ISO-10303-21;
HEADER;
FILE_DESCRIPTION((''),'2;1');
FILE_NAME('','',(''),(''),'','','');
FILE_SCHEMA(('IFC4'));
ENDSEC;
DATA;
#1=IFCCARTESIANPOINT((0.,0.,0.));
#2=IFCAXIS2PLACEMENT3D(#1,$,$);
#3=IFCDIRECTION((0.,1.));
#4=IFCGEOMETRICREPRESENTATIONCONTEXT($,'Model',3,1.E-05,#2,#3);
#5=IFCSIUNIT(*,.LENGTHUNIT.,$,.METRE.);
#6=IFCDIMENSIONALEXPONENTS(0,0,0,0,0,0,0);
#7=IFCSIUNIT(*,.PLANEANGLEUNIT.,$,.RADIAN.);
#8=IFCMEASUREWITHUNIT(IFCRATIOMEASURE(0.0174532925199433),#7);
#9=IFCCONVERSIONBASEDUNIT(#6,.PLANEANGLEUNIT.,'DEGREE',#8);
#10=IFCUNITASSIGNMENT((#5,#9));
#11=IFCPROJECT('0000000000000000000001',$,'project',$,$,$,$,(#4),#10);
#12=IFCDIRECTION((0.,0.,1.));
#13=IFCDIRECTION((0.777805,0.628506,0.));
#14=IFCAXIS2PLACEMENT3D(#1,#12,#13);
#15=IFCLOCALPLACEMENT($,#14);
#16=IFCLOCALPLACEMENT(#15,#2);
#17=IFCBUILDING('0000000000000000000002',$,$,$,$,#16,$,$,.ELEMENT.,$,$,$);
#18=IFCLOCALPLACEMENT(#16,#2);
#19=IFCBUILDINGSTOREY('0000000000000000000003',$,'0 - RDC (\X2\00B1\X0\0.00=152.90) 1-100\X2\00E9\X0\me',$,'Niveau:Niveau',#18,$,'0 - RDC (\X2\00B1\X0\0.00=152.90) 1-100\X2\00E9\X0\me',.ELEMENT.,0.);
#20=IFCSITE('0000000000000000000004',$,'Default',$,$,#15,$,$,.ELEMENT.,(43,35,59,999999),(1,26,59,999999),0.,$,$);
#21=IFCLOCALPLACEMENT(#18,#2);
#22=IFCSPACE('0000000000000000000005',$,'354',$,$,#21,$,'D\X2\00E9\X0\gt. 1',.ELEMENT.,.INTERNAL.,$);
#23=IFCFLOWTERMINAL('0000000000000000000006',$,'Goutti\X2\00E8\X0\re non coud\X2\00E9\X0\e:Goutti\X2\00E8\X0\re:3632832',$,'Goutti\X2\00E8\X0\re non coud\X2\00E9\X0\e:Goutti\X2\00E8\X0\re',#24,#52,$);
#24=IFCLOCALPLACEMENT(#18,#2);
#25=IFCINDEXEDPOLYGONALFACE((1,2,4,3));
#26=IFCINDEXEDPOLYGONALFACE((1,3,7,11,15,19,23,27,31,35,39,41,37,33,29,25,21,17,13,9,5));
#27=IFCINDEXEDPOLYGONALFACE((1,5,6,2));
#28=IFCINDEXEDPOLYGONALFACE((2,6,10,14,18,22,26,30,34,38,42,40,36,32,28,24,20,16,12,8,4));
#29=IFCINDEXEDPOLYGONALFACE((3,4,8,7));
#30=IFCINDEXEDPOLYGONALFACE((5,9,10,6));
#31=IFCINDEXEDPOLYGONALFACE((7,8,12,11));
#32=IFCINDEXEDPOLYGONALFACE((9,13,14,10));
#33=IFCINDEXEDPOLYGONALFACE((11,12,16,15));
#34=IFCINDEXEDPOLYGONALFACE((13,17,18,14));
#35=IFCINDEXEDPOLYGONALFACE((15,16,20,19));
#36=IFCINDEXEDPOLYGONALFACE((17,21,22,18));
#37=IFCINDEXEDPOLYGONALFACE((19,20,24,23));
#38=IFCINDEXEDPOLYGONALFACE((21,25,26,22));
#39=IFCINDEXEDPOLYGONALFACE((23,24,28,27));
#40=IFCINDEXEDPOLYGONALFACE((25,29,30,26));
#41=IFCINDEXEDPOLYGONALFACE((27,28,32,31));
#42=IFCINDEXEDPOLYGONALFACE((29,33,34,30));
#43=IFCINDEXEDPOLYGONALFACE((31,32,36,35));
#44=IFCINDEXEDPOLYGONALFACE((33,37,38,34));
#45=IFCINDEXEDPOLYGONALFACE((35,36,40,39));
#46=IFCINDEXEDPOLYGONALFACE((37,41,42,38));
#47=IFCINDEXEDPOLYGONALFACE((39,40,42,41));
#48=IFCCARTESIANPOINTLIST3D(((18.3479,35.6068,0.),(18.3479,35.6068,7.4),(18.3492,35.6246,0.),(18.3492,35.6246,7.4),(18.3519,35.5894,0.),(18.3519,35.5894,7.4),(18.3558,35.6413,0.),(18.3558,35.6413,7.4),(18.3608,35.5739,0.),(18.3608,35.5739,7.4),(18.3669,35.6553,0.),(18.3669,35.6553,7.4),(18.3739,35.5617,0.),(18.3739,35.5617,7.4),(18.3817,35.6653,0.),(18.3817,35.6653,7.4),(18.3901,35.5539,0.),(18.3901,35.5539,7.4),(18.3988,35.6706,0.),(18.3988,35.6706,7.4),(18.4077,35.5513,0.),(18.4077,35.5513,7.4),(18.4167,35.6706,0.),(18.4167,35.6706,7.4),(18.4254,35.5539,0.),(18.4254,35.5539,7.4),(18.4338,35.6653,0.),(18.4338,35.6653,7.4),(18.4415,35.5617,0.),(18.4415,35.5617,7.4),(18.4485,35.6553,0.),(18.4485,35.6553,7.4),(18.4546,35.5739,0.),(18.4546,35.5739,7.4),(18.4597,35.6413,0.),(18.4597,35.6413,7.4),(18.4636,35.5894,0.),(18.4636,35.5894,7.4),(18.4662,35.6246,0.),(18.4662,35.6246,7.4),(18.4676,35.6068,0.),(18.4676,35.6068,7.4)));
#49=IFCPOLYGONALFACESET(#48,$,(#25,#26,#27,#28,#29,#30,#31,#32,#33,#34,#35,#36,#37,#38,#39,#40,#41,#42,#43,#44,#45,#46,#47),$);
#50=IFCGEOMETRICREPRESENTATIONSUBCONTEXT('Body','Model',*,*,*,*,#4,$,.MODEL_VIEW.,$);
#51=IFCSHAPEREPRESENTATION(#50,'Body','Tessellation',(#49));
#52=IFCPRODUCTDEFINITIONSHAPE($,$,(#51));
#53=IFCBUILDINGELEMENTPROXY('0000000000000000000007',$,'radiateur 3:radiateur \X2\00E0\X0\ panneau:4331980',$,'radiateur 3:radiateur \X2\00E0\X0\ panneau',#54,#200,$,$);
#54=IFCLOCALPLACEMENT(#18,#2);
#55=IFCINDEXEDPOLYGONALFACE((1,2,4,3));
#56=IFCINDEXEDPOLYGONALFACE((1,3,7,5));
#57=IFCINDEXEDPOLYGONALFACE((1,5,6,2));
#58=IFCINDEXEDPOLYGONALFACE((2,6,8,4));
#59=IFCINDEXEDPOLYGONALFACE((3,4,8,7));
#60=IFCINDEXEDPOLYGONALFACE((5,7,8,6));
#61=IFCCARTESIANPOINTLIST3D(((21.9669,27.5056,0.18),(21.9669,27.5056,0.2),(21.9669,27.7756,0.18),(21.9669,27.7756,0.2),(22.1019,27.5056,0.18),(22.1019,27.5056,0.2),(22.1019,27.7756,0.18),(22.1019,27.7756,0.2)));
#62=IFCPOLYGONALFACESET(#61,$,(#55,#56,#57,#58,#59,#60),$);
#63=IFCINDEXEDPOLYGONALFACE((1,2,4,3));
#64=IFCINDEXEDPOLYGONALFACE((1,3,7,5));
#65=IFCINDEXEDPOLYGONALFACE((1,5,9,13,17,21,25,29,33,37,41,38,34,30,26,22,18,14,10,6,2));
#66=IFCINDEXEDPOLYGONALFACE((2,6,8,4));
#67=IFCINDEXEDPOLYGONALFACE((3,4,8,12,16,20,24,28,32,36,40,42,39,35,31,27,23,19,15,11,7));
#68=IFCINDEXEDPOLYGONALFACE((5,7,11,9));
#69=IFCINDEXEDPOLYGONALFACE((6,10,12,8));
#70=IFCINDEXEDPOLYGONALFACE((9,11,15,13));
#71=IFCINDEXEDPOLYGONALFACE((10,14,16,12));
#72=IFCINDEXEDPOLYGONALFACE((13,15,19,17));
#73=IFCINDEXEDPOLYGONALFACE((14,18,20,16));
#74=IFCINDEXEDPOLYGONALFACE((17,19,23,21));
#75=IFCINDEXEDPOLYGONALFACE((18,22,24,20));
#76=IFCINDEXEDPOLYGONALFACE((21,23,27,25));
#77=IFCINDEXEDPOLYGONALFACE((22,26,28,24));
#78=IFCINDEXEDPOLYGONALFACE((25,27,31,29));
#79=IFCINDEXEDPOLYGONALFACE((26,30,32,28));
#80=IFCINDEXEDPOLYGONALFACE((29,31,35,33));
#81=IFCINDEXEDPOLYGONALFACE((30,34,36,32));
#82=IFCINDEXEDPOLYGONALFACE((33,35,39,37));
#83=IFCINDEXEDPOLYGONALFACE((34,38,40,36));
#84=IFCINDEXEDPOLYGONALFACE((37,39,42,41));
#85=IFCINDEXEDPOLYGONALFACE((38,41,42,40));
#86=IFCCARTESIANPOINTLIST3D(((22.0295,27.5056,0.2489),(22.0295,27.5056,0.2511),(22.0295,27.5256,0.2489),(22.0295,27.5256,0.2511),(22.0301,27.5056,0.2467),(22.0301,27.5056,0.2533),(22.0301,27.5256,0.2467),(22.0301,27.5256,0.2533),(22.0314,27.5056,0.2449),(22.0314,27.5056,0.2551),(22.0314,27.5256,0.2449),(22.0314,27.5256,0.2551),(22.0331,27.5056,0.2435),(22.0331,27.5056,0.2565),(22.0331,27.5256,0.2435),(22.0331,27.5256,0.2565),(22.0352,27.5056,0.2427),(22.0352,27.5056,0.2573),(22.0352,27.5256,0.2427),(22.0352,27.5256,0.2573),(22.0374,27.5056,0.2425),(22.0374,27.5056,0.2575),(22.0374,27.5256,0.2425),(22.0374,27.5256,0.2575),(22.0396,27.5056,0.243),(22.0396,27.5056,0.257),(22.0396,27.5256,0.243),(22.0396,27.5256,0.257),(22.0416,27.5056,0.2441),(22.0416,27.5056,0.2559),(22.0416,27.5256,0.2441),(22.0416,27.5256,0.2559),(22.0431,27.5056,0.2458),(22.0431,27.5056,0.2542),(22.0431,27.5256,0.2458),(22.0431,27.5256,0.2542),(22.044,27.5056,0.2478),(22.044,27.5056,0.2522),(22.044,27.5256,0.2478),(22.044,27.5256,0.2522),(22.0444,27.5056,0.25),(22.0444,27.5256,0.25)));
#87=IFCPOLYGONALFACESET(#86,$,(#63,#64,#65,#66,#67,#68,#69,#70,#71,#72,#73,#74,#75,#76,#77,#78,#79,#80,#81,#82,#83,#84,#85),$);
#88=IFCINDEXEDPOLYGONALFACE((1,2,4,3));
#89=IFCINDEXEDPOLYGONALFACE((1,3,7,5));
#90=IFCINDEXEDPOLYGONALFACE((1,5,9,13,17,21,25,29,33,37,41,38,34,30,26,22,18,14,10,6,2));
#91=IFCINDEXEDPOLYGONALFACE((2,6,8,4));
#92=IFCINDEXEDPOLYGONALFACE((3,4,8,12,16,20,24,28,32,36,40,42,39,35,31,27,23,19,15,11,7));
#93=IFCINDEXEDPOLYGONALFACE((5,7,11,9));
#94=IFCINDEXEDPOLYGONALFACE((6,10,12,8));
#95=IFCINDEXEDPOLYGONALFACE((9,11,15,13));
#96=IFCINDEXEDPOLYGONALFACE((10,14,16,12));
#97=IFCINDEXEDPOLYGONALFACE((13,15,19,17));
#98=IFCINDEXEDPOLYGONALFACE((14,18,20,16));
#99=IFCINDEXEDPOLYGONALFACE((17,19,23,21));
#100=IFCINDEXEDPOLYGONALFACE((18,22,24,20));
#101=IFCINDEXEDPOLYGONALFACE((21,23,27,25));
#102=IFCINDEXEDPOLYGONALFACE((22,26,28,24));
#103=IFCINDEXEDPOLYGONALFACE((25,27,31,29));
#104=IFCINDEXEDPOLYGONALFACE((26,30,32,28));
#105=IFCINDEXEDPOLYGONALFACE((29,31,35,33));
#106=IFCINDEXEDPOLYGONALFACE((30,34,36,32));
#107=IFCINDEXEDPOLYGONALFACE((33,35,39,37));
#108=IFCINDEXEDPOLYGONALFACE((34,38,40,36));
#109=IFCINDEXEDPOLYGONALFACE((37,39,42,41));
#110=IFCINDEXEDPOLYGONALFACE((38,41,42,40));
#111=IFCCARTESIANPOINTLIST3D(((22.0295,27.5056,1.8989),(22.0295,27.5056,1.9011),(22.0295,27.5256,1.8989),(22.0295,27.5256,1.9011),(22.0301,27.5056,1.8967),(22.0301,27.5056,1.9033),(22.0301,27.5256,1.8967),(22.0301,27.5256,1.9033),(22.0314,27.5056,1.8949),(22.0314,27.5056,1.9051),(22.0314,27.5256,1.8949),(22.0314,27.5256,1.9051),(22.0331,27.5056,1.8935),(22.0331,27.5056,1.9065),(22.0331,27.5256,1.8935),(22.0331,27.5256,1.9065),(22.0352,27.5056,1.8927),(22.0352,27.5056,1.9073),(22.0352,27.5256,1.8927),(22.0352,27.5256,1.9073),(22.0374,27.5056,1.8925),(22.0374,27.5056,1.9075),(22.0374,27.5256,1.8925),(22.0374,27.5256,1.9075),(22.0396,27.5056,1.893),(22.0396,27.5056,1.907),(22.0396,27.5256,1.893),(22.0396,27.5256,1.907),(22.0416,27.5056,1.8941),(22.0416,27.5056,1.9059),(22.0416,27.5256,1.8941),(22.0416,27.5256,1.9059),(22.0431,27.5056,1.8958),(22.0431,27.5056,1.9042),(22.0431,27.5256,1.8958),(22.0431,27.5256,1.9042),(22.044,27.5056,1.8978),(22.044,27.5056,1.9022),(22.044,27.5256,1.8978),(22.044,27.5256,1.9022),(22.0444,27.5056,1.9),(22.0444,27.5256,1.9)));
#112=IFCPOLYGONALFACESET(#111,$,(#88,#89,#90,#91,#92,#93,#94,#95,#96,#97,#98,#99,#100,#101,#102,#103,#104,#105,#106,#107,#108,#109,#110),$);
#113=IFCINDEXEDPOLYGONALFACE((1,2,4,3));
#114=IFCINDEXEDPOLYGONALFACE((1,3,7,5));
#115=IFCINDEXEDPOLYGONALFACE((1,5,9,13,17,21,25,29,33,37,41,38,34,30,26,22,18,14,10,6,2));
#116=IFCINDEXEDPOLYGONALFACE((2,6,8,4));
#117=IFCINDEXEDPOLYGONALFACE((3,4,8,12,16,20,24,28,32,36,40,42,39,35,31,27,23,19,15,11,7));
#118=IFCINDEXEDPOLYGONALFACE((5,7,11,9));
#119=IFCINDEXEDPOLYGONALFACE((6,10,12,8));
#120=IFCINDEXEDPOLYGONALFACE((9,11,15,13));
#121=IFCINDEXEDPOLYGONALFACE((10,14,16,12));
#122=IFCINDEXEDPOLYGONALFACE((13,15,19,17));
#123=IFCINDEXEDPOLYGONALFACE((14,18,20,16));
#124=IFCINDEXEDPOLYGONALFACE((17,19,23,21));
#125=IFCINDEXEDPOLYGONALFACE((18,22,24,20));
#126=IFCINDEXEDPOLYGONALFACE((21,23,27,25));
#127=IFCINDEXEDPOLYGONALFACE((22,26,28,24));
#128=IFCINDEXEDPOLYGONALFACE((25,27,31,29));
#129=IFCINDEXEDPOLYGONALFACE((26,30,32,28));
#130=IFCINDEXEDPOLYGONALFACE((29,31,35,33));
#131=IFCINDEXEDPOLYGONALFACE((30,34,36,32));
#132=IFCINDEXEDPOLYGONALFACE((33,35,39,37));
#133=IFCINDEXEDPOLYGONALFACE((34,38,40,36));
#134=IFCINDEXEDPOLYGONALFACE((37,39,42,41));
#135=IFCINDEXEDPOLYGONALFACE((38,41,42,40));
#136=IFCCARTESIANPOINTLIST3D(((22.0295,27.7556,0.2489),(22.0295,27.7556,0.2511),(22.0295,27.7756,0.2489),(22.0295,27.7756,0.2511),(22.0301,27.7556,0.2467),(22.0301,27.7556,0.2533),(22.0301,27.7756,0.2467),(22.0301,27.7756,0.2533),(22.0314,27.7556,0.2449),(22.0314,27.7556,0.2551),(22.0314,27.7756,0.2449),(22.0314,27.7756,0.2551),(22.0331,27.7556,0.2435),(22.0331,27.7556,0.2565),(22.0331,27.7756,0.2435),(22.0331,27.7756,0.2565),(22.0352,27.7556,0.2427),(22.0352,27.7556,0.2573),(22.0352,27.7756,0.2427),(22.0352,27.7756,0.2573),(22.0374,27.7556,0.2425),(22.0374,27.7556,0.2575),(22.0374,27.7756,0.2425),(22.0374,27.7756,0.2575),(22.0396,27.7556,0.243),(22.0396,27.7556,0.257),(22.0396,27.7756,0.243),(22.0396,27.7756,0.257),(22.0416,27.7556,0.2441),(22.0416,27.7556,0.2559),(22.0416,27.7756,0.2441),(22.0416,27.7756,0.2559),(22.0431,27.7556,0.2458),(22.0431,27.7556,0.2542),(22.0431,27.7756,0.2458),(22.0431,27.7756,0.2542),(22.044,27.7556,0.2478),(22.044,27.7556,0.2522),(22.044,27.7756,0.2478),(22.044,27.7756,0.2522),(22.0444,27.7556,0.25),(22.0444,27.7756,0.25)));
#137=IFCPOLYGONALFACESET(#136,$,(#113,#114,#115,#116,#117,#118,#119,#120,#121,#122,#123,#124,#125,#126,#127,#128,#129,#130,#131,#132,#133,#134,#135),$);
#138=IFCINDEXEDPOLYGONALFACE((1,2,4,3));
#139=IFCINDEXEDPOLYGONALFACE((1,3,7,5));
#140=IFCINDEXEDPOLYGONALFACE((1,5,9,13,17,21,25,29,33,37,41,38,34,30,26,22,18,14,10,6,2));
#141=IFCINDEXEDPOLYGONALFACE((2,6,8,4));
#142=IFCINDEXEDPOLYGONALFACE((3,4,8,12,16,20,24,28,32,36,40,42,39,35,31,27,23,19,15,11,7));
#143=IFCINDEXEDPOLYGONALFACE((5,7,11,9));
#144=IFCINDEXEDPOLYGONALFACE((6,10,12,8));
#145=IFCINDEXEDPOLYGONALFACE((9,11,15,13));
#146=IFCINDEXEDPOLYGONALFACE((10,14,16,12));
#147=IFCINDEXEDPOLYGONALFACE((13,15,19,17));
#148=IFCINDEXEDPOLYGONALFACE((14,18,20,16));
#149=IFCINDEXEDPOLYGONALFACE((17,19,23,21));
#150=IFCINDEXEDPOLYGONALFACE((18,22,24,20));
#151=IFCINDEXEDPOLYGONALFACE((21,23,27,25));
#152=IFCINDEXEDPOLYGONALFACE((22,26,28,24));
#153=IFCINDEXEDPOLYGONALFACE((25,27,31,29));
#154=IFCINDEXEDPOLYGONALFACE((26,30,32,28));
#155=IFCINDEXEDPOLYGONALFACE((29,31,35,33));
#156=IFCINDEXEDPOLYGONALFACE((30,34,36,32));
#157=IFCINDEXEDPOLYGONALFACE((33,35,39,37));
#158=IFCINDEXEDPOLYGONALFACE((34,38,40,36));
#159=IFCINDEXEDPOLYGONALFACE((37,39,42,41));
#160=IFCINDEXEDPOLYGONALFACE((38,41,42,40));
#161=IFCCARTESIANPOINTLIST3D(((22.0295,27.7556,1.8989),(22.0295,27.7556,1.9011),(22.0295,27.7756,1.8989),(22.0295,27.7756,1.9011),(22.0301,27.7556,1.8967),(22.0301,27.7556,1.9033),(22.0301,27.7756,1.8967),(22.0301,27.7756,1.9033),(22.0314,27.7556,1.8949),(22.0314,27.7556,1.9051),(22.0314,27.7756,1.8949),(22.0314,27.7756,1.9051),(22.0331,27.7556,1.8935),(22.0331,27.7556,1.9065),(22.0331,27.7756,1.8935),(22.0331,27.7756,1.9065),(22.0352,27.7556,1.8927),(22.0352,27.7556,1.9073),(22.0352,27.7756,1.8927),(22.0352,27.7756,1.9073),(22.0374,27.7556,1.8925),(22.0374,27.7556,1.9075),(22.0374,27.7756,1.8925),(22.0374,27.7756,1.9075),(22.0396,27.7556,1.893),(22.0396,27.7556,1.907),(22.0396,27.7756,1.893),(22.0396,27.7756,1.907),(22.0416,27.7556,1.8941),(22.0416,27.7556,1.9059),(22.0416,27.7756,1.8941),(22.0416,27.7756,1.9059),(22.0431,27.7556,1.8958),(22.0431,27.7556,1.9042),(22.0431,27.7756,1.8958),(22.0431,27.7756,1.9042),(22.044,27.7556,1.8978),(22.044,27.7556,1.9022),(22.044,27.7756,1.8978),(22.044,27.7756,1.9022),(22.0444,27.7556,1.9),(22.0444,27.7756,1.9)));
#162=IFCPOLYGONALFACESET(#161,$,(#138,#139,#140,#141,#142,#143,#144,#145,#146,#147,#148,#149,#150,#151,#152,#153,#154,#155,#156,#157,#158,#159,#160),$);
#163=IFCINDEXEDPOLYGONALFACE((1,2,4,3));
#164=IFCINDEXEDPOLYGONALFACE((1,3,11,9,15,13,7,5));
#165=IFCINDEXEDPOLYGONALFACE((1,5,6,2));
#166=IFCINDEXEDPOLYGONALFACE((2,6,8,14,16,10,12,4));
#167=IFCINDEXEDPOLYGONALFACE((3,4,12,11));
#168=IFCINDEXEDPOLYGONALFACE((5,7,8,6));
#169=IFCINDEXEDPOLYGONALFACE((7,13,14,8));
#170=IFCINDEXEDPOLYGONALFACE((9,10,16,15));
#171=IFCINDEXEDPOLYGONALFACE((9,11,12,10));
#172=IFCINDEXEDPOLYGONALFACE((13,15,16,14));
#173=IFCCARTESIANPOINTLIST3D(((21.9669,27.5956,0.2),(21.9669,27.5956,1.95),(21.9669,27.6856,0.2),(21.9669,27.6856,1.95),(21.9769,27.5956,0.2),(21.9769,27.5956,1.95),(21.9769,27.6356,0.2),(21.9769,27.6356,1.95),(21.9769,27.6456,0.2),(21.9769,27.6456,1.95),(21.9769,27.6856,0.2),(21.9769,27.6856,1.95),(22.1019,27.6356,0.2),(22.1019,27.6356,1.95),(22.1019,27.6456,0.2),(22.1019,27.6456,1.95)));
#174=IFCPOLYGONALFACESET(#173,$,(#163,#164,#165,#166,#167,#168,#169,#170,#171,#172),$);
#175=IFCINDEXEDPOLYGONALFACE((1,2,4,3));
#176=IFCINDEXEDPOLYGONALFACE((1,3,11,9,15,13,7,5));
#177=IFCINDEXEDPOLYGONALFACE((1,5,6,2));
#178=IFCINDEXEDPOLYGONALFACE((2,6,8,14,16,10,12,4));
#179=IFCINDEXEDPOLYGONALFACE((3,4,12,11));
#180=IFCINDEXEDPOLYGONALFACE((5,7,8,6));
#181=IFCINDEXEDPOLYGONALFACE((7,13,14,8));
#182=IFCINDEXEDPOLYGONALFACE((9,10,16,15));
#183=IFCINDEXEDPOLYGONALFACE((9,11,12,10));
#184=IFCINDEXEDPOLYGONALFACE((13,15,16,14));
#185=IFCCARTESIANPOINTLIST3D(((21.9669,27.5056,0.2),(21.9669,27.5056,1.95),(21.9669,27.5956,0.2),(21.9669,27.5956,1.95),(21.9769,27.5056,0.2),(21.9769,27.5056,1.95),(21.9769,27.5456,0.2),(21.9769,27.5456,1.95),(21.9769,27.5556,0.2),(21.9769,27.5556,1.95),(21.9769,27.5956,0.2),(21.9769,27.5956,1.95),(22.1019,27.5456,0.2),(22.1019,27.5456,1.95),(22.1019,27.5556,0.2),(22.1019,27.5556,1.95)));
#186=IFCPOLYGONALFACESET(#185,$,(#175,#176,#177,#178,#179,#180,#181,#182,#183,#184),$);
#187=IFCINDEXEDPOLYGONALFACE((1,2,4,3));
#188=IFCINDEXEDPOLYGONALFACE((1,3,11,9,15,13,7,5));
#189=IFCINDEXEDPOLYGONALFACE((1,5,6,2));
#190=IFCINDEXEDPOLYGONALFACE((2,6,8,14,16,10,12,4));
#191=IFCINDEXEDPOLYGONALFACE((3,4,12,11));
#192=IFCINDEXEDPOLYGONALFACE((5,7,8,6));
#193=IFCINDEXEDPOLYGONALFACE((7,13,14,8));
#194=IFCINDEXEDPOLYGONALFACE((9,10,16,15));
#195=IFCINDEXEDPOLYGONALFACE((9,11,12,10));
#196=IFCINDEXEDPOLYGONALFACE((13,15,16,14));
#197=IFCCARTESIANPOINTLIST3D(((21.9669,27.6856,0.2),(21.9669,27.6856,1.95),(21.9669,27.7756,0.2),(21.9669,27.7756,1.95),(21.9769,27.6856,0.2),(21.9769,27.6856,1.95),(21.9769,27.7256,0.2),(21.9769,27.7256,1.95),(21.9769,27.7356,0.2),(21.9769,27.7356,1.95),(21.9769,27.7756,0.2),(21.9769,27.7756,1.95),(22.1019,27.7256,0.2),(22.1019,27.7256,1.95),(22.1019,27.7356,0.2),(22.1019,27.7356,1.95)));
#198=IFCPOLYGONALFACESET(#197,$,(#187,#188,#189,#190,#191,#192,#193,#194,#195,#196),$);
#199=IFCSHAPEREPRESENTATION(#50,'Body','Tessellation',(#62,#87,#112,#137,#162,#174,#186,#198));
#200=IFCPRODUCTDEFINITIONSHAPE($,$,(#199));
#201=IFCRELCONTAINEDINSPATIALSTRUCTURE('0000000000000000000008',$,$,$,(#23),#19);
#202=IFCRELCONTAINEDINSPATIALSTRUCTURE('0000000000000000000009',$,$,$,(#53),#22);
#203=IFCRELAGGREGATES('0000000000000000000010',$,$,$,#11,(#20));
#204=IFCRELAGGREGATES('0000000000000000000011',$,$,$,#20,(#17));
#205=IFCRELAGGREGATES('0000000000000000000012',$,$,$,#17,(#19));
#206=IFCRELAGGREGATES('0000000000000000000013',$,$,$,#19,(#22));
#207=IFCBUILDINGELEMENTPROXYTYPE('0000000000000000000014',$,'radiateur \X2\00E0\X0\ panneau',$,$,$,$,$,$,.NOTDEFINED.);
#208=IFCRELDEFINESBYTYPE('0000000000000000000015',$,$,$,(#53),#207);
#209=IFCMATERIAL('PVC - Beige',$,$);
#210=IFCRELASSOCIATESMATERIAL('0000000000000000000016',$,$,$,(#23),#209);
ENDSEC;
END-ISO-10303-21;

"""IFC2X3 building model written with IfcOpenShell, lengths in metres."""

from ifc_helpers import new_model, entity, si_unit, converted_unit, direction, frame, frame_2d, origin, origin_2d_with_axis, place, context, subcontext, project, spatial, polyline, rectangle, circle, outline, extrude, source, transform, mapped, material, type_object, type_shapes, element, save


model = new_model("IFC2X3")

# Units and contexts
model_context = context("Model", 3, precision=1e-05, world=origin(), true_north=direction((0.0, 1.0)))
body_context = subcontext(model_context, "Body", "Model", "MODEL_VIEW")
ifc_project = project(units=[si_unit("LENGTHUNIT", "METRE"), converted_unit("PLANEANGLEUNIT", "DEGREE", entity("IfcRatioMeasure", 0.0174532925199433), si_unit("PLANEANGLEUNIT", "RADIAN"), dimensions=[0, 0, 0, 0, 0, 0, 0])], contexts=[model_context])

# Site, building, storey
site_placement = place(None, frame((0.0, 0.0, 0.0), z_axis=(0.0, 0.0, 1.0), x_axis=(0.777805, 0.628506, 0.0)))
site = spatial("IfcSite", under=ifc_project, at=site_placement, Name="Default", CompositionType="ELEMENT", RefLatitude=(43, 35, 59, 999999), RefLongitude=(1, 26, 59, 999999), RefElevation=0.0)
building_placement = place(site_placement, origin())
building = spatial("IfcBuilding", under=site, at=building_placement, CompositionType="ELEMENT")
storey_placement = place(building_placement, origin())
storey = spatial("IfcBuildingStorey", under=building, at=storey_placement, Name="0 - RDC (±0.00=152.90) 1-100éme", ObjectType="Niveau:Niveau", LongName="0 - RDC (±0.00=152.90) 1-100éme", CompositionType="ELEMENT", Elevation=0.0)

# Flow terminal
ifc_material_1 = material(Name="PVC - Beige")
shared_shape_1 = source(origin(), body_context, "Body", "SweptSolid", [
    extrude(circle(Radius=0.06, at=frame_2d((0.0, 0.0), x_axis=(1.0, 0.0))), frame((0.0, 0.0, 0.0), z_axis=(0.0, 0.0, 1.0), x_axis=(0.0, -1.0, 0.0)), (0.0, 0.0, 1.0), 7.4),
])
flow_terminal_1_placement = place(storey_placement, frame((18.4077, 35.6113, 0.0)))
element("IfcFlowTerminal", 1, at=flow_terminal_1_placement, inside=storey, material=ifc_material_1, Name="Gouttière non coudée:Gouttière:3632832", ObjectType="Gouttière non coudée:Gouttière", context=body_context, shape_type="MappedRepresentation", body=[
    mapped(shared_shape_1, transform((0.0, 0.0, 0.0), scale=1.0)),
])

# Shared definitions
space_1_placement = place(storey_placement, origin())
space_1 = spatial("IfcSpace", under=storey, at=space_1_placement, Name="354", LongName="Dégt. 1", CompositionType="ELEMENT", InteriorOrExteriorSpace="INTERNAL")

# Building element proxy
building_element_proxy_type_1 = type_object("IfcBuildingElementProxyType", Name="radiateur à panneau", PredefinedType="NOTDEFINED")
shared_shape_2 = source(origin(), body_context, "Body", "SweptSolid", [
    extrude(rectangle(XDim=0.135, YDim=0.27, at=frame_2d((0.0, 0.0), x_axis=(1.0, 0.0))), frame((0.135, -0.0025, -0.02), z_axis=(0.0, 0.0, 1.0), x_axis=(0.0, -1.0, 0.0)), (0.0, 0.0, 1.0), 0.02),
    extrude(circle(Radius=0.0075, at=frame_2d((0.0, 0.0), x_axis=(1.0, 0.0))), frame((0.25, 0.0, 0.05), z_axis=(1.0, 0.0, 0.0), x_axis=(0.0, 1.0, 0.0)), (0.0, 0.0, 1.0), 0.02),
    extrude(circle(Radius=0.0075, at=frame_2d((0.0, 0.0), x_axis=(1.0, 0.0))), frame((0.25, 0.0, 1.7), z_axis=(1.0, 0.0, 0.0), x_axis=(0.0, 1.0, 0.0)), (0.0, 0.0, 1.0), 0.02),
    extrude(circle(Radius=0.0075, at=frame_2d((0.0, 0.0), x_axis=(1.0, 0.0))), frame((0.0, 0.0, 0.05), z_axis=(1.0, 0.0, 0.0), x_axis=(0.0, 1.0, 0.0)), (0.0, 0.0, 1.0), 0.02),
    extrude(circle(Radius=0.0075, at=origin_2d_with_axis()), frame((0.0, 0.0, 1.7), z_axis=(1.0, 0.0, 0.0), x_axis=(0.0, 1.0, 0.0)), (0.0, 0.0, 1.0), 0.02),
    extrude(outline(polyline([(-0.005, -0.0963), (0.005, -0.0963), (0.005, 0.0288), (0.045, 0.0288), (0.045, 0.0387), (-0.045, 0.0387), (-0.045, 0.0288), (-0.005, 0.0288), (-0.005, -0.0963)])), frame((0.135, -0.0313, 0.0), z_axis=(0.0, 0.0, 1.0), x_axis=(-1.0, 0.0, 0.0)), (0.0, 0.0, 1.0), 1.75),
    extrude(outline(polyline([(-0.005, -0.0963), (0.005, -0.0963), (0.005, 0.0288), (0.045, 0.0288), (0.045, 0.0387), (-0.045, 0.0387), (-0.045, 0.0288), (-0.005, 0.0288), (-0.005, -0.0963)])), frame((0.225, -0.0313, 0.0), z_axis=(0.0, 0.0, 1.0), x_axis=(-1.0, 0.0, 0.0)), (0.0, 0.0, 1.0), 1.75),
    extrude(outline(polyline([(-0.005, -0.0963), (0.005, -0.0963), (0.005, 0.0288), (0.045, 0.0288), (0.045, 0.0387), (-0.045, 0.0387), (-0.045, 0.0288), (-0.005, 0.0288), (-0.005, -0.0963)])), frame((0.045, -0.0313, 0.0), z_axis=(0.0, 0.0, 1.0), x_axis=(-1.0, 0.0, 0.0)), (0.0, 0.0, 1.0), 1.75),
])
type_shapes(building_element_proxy_type_1, [shared_shape_2])
proxy_1_placement = place(space_1_placement, frame((22.0369, 27.7756, 0.2), z_axis=(0.0, 0.0, 1.0), x_axis=(0.0, -1.0, 0.0)))
element("IfcBuildingElementProxy", 2, at=proxy_1_placement, inside=space_1, type_object=building_element_proxy_type_1, Name="radiateur 3:radiateur à panneau:4331980", ObjectType="radiateur 3:radiateur à panneau", context=body_context, shape_type="MappedRepresentation", body=[
    mapped(shared_shape_2, transform((0.0, 0.0, 0.0), scale=1.0)),
])

save(model, "model.ifc")
